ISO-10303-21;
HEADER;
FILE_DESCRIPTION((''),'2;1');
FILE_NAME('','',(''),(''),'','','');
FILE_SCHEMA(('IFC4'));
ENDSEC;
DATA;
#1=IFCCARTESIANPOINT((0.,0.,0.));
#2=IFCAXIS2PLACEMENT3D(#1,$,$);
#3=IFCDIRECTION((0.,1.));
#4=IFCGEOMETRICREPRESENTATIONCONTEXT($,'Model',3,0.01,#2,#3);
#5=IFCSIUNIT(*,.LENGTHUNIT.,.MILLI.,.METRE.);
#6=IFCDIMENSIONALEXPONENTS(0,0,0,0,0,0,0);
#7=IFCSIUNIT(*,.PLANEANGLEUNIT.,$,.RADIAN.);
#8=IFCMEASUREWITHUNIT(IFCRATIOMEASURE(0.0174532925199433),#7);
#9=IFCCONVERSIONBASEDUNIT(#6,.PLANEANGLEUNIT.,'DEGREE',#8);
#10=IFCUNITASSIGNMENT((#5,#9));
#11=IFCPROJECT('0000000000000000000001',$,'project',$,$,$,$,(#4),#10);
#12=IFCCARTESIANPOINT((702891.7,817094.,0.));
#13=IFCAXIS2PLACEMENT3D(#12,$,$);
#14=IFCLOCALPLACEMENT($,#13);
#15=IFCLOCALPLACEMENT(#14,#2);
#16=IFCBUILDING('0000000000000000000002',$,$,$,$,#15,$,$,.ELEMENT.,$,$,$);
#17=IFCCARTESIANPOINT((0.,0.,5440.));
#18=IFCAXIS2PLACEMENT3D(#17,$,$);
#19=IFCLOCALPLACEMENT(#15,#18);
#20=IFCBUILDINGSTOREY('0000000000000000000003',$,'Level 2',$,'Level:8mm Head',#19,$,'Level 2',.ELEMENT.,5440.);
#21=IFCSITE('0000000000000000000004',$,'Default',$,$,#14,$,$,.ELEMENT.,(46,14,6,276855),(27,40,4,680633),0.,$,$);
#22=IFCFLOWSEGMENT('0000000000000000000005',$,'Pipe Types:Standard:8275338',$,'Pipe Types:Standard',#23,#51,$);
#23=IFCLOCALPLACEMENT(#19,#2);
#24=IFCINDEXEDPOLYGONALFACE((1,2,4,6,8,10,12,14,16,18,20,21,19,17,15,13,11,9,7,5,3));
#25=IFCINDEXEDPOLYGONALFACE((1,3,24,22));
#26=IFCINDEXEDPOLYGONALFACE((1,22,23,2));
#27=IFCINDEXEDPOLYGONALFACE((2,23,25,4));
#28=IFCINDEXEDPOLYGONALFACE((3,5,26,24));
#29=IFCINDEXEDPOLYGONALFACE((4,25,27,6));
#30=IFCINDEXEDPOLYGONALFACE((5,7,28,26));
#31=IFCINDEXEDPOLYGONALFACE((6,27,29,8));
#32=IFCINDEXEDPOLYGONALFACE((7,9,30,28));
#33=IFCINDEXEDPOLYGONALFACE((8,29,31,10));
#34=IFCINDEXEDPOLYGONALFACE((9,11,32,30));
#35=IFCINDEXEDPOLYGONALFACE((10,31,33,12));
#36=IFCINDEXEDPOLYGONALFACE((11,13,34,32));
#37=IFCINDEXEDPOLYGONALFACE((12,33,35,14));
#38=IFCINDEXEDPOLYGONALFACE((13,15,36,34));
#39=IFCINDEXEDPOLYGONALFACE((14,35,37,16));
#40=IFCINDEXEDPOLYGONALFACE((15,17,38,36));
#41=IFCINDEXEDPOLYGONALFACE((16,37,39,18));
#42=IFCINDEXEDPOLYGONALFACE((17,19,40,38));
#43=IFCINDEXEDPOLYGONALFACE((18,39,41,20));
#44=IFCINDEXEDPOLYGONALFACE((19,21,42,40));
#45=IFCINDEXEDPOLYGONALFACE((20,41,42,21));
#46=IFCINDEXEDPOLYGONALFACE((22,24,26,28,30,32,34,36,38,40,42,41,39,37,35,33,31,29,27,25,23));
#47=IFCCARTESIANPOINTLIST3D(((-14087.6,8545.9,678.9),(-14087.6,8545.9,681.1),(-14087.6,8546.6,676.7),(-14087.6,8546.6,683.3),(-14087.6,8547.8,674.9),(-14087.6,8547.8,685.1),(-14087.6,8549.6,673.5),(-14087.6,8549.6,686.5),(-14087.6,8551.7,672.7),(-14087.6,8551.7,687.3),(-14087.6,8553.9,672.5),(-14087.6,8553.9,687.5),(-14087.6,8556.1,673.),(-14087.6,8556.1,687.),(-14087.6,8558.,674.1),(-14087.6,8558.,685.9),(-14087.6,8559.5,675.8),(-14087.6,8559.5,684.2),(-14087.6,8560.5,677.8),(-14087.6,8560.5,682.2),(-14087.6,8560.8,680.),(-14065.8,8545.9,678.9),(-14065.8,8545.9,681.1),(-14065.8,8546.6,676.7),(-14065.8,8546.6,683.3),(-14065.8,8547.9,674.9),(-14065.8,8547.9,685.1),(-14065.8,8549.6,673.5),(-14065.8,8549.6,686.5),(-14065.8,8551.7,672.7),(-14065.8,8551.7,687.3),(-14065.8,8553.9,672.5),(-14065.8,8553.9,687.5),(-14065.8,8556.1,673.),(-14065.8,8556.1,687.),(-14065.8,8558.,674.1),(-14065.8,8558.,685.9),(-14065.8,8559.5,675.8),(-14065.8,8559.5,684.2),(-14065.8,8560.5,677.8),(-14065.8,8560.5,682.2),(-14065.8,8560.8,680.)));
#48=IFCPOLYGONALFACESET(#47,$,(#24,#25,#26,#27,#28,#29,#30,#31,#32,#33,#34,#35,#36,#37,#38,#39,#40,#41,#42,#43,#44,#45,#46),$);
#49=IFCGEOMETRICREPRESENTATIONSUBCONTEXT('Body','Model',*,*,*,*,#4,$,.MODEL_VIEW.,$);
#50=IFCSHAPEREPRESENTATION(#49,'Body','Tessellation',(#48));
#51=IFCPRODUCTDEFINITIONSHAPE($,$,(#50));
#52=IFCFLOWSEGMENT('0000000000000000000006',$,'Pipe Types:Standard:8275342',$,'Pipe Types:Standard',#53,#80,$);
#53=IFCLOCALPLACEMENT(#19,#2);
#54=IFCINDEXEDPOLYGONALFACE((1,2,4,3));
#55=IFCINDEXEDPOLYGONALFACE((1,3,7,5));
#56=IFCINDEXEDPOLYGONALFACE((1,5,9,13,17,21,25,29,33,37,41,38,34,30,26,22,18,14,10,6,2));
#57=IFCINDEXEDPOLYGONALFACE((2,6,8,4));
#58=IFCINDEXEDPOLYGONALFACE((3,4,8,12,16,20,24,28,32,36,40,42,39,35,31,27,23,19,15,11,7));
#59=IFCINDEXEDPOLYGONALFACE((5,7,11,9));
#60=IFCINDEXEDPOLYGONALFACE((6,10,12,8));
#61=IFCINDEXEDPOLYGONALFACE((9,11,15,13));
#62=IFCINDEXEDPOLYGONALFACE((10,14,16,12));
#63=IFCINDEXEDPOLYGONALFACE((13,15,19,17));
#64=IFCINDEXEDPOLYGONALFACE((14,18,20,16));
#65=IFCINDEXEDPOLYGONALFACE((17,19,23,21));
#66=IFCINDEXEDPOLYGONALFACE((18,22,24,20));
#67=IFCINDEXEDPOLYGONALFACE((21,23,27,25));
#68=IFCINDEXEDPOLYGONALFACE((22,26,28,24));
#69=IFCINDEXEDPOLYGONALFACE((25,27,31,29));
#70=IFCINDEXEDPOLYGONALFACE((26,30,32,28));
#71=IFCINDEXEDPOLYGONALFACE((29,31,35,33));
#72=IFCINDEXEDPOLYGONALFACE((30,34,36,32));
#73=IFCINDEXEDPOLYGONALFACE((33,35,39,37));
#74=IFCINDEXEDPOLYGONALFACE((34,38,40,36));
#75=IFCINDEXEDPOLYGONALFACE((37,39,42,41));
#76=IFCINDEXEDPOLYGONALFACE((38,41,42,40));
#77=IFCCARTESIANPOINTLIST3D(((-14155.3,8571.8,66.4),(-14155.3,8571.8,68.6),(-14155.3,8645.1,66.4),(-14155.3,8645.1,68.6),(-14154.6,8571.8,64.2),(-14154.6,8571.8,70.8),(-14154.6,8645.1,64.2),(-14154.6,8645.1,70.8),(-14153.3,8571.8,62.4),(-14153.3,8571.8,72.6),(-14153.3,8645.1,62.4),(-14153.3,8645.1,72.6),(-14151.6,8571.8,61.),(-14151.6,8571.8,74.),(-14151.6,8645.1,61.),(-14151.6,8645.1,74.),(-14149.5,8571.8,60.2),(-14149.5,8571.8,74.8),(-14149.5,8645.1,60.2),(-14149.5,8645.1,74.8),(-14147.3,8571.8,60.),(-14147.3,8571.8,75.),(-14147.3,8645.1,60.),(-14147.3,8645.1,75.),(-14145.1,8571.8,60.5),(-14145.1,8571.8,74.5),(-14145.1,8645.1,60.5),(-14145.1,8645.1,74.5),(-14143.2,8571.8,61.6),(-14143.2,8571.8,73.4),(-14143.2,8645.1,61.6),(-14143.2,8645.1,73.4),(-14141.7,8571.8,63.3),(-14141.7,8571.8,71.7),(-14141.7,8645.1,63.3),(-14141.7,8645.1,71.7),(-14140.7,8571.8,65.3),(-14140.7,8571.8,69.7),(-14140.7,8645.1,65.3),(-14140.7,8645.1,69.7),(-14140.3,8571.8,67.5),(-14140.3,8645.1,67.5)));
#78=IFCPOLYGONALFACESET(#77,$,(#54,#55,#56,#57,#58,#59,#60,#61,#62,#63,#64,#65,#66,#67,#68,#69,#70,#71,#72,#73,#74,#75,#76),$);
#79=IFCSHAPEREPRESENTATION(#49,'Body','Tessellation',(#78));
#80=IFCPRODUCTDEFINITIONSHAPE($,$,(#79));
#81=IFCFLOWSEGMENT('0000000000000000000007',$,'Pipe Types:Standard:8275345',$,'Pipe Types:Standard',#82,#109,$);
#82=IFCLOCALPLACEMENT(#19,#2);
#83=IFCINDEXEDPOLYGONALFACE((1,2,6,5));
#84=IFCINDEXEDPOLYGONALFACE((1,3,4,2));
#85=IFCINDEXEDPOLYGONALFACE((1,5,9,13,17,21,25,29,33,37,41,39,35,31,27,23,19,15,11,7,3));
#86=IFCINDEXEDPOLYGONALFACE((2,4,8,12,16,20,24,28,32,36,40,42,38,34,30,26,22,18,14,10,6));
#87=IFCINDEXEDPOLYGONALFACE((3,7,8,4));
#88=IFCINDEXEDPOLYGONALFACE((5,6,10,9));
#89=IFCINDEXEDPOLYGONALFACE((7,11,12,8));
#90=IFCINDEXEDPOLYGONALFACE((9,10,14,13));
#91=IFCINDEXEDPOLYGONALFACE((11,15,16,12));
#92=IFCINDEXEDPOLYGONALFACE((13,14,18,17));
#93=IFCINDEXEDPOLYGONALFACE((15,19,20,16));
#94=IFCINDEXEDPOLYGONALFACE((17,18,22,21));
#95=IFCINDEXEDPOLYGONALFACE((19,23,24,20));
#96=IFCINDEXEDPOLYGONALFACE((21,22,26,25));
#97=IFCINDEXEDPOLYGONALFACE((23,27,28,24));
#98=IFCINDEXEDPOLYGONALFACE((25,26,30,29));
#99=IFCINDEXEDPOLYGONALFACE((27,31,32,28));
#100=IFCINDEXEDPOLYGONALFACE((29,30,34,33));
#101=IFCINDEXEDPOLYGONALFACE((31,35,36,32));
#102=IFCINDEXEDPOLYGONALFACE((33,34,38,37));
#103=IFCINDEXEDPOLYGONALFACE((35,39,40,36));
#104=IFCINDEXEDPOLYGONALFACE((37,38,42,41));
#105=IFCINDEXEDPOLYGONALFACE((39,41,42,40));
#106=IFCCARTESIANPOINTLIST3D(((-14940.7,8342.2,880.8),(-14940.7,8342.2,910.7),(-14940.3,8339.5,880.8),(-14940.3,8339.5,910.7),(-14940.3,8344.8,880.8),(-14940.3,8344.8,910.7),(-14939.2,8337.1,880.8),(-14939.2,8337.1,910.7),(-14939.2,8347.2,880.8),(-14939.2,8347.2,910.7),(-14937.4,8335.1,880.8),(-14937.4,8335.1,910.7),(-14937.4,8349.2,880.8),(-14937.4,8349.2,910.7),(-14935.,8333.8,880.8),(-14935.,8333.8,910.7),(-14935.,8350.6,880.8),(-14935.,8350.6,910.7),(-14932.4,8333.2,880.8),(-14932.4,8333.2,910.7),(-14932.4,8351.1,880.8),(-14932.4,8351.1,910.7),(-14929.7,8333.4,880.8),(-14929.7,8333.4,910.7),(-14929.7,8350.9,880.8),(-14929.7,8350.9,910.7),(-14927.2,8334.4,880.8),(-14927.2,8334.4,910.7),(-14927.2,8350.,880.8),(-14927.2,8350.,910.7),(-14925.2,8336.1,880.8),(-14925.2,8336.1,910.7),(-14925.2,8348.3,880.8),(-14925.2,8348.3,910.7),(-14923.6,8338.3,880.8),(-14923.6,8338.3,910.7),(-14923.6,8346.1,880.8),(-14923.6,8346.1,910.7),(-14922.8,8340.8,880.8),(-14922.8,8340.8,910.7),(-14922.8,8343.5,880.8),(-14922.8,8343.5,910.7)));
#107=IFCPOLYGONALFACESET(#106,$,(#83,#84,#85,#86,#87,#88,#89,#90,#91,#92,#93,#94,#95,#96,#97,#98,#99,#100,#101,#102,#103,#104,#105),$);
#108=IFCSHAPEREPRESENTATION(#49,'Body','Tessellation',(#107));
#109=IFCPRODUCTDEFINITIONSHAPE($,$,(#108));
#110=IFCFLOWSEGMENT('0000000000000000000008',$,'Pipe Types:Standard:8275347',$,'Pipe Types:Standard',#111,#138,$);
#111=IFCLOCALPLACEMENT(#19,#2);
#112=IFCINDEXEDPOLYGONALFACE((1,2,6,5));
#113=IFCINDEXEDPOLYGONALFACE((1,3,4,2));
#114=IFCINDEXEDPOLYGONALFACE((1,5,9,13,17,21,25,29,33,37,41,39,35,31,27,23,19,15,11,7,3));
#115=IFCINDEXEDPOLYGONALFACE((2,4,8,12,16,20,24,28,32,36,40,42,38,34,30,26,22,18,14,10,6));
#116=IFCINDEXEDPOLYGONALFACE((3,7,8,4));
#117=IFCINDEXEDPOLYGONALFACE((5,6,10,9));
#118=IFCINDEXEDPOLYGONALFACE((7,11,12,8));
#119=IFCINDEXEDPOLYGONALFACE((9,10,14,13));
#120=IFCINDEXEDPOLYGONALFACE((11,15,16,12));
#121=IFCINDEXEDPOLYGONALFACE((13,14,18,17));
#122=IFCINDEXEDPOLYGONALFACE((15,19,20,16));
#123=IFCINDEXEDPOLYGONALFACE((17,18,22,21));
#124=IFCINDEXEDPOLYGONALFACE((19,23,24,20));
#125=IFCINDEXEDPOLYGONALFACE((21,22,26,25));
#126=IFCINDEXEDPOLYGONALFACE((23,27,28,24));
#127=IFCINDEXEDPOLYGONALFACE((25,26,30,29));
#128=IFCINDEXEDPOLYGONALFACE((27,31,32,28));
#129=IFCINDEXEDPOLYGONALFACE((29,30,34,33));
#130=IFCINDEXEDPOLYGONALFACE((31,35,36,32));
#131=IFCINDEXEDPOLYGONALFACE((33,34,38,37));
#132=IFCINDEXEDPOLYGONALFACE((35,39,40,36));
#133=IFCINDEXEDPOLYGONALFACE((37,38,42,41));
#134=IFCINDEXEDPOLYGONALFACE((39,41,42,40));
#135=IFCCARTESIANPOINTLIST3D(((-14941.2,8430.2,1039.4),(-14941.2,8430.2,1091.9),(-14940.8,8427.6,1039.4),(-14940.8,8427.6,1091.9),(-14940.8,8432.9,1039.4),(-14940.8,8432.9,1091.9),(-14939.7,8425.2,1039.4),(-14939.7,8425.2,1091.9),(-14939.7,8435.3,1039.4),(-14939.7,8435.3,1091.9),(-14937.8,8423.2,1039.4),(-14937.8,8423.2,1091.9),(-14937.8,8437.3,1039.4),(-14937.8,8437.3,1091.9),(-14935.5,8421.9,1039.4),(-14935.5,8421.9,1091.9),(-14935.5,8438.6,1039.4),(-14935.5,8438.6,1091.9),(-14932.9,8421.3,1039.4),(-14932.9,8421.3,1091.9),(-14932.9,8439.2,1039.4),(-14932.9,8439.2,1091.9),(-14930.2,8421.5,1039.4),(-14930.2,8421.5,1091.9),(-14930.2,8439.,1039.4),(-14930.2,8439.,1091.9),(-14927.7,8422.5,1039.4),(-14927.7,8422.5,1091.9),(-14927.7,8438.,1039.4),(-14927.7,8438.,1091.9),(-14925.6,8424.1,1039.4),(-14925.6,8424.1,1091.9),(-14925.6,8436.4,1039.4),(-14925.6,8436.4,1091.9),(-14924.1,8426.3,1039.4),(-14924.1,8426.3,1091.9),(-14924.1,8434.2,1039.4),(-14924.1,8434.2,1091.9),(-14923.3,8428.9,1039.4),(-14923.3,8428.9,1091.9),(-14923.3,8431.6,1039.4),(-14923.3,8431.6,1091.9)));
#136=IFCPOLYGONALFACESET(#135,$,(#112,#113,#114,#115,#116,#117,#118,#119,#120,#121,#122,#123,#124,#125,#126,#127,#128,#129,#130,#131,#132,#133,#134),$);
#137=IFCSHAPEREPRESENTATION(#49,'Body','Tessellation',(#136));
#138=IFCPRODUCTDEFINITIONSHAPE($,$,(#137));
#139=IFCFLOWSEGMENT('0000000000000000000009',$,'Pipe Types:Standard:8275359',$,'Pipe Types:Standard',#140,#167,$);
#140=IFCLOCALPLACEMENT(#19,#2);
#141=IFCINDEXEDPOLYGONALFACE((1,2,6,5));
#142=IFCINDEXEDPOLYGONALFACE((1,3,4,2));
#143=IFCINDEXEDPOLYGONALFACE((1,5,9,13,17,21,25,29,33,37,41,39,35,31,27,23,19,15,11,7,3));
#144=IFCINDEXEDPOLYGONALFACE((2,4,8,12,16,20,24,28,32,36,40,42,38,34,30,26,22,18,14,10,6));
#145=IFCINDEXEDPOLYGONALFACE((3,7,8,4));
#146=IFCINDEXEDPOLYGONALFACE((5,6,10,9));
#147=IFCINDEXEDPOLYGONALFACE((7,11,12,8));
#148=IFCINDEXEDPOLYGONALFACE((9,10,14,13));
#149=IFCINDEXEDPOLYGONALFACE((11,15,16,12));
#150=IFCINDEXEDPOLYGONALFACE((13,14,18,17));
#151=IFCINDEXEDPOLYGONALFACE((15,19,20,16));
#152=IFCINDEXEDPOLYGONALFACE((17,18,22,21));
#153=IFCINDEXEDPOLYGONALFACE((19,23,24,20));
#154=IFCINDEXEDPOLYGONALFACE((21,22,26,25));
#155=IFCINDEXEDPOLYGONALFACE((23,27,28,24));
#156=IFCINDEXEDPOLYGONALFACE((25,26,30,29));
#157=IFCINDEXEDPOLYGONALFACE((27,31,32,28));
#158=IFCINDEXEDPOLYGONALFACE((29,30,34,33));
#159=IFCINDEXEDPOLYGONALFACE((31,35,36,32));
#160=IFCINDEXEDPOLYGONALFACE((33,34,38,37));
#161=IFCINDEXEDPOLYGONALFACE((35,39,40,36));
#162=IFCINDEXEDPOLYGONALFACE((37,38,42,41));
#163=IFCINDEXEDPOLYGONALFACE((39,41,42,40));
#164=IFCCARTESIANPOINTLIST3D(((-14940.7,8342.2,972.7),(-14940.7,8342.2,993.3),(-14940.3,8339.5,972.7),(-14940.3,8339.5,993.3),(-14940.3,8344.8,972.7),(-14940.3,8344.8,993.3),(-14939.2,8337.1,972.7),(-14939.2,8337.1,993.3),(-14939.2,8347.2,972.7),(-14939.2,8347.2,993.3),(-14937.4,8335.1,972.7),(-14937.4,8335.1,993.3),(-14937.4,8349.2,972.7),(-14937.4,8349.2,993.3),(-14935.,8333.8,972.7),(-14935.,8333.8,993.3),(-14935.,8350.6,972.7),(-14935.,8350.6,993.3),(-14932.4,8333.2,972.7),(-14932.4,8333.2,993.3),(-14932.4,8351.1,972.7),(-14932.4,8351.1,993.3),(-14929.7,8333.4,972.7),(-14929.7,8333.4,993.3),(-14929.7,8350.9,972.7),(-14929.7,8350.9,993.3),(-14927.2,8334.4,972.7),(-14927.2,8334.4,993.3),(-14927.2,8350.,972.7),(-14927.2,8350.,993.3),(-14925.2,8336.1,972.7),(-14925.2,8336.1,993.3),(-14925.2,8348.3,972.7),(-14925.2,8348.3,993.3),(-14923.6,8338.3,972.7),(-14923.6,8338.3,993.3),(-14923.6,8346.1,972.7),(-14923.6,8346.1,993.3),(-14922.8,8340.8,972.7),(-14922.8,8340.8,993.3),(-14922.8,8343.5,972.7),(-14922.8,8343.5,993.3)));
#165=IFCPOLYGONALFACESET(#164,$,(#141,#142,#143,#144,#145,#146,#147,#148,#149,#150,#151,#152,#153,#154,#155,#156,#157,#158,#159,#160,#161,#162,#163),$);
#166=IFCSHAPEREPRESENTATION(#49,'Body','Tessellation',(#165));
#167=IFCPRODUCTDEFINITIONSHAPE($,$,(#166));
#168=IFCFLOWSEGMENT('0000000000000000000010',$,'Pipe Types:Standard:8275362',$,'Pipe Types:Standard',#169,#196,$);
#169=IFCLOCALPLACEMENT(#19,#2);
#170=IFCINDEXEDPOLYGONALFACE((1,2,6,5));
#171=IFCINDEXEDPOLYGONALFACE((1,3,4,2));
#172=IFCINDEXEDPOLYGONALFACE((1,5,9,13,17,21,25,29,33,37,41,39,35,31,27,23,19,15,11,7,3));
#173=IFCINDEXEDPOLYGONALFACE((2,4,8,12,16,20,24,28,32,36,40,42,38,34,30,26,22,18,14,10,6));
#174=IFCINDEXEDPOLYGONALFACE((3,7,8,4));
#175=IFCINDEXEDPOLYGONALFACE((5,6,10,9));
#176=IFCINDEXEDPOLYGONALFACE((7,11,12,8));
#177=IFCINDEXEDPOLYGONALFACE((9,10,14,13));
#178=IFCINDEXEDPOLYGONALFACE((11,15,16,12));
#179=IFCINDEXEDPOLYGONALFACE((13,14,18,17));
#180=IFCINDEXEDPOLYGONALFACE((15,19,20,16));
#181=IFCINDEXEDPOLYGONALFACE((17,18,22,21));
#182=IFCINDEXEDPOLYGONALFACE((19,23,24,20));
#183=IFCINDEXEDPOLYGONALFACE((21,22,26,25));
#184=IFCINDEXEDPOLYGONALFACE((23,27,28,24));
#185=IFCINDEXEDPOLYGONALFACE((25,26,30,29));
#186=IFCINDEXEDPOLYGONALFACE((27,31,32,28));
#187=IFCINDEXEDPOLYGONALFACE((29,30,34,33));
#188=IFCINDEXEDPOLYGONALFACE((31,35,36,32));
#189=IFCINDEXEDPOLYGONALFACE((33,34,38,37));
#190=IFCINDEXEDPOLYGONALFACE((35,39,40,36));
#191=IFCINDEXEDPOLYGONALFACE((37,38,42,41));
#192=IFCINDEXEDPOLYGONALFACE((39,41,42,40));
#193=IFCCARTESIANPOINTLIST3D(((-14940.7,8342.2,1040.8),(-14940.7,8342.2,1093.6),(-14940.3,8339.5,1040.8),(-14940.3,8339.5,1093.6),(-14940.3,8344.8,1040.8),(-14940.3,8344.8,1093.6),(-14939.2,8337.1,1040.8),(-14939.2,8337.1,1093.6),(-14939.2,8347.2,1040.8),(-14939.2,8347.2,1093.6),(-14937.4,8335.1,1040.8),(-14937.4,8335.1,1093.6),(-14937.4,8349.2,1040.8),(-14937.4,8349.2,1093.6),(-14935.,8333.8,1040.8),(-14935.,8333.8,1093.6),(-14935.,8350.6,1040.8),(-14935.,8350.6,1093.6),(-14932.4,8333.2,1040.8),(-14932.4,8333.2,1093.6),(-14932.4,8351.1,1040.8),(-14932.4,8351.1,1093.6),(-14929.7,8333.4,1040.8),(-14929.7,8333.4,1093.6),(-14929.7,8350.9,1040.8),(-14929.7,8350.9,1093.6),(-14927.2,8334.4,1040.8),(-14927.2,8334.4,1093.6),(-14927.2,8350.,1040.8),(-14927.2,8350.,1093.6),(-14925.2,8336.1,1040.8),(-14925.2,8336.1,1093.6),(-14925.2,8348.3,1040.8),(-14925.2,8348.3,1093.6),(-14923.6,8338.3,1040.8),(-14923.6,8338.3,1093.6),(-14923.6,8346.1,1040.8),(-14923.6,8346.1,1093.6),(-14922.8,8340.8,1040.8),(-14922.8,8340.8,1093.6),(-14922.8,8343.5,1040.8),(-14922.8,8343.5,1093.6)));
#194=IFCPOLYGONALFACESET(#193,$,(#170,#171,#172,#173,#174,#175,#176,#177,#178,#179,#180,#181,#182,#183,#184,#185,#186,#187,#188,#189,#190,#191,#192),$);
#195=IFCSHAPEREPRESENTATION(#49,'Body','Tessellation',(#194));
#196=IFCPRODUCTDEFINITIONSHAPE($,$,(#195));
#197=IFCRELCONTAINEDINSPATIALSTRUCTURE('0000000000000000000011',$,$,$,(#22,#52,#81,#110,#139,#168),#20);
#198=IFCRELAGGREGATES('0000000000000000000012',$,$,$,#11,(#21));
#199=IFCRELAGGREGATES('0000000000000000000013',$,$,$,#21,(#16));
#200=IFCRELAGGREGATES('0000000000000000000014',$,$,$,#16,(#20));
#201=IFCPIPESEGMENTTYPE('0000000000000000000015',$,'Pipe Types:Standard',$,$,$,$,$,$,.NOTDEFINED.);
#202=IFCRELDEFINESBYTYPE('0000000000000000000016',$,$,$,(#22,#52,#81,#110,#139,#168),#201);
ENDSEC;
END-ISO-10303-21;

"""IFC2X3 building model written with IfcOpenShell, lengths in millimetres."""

from ifc_helpers import new_model, entity, si_unit, converted_unit, direction, frame, frame_2d, origin, origin_2d_with_axis, place, context, subcontext, project, spatial, circle, extrude, type_object, element, save


model = new_model("IFC2X3")

# Units and contexts
model_context = context("Model", 3, precision=0.01, world=origin(), true_north=direction((0.0, 1.0)))
body_context = subcontext(model_context, "Body", "Model", "MODEL_VIEW")
ifc_project = project(units=[si_unit("LENGTHUNIT", "METRE", prefix="MILLI"), converted_unit("PLANEANGLEUNIT", "DEGREE", entity("IfcRatioMeasure", 0.0174532925199433), si_unit("PLANEANGLEUNIT", "RADIAN"), dimensions=[0, 0, 0, 0, 0, 0, 0])], contexts=[model_context])

# Site, building, storey
site_placement = place(None, frame((702891.7, 817094.0, 0.0)))
site = spatial("IfcSite", under=ifc_project, at=site_placement, Name="Default", CompositionType="ELEMENT", RefLatitude=(46, 14, 6, 276855), RefLongitude=(27, 40, 4, 680633), RefElevation=0.0)
building_placement = place(site_placement, origin())
building = spatial("IfcBuilding", under=site, at=building_placement, CompositionType="ELEMENT")
storey_placement = place(building_placement, frame((0.0, 0.0, 5440.0)))
storey = spatial("IfcBuildingStorey", under=building, at=storey_placement, Name="Level 2", ObjectType="Level:8mm Head", LongName="Level 2", CompositionType="ELEMENT", Elevation=5440.0)

# Flow segments
pipe_segment_type = type_object("IfcPipeSegmentType", Name="Pipe Types:Standard", PredefinedType="NOTDEFINED")
flow_segment_1_placement = place(storey_placement, origin())
element("IfcFlowSegment", 1, at=flow_segment_1_placement, inside=storey, type_object=pipe_segment_type, Name="Pipe Types:Standard:8275338", ObjectType="Pipe Types:Standard", context=body_context, shape_type="SweptSolid", body=[
    extrude(circle(Radius=7.5, at=origin_2d_with_axis()), frame((-14087.6, 8553.3, 680.0), z_axis=(1.0, 0.000154, 0.0), x_axis=(-0.000154, 1.0, 0.0)), (0.0, 0.0, 1.0), 21.8),
])
flow_segment_2_placement = place(storey_placement, origin())
element("IfcFlowSegment", 2, at=flow_segment_2_placement, inside=storey, type_object=pipe_segment_type, Name="Pipe Types:Standard:8275342", ObjectType="Pipe Types:Standard", context=body_context, shape_type="SweptSolid", body=[
    extrude(circle(Radius=7.5, at=origin_2d_with_axis()), frame((-14147.8, 8571.8, 67.5), z_axis=(0.0, 1.0, 0.0), x_axis=(1.0, 0.0, 0.0)), (0.0, 0.0, 1.0), 73.3),
])
flow_segment_3_placement = place(storey_placement, origin())
element("IfcFlowSegment", 3, at=flow_segment_3_placement, inside=storey, type_object=pipe_segment_type, Name="Pipe Types:Standard:8275345", ObjectType="Pipe Types:Standard", context=body_context, shape_type="SweptSolid", body=[
    extrude(circle(Radius=9.0, at=origin_2d_with_axis()), frame((-14931.7, 8342.2, 880.8), z_axis=(0.0, 0.0, 1.0), x_axis=(-1.0, 0.0, 0.0)), (0.0, 0.0, 1.0), 29.9),
])
flow_segment_4_placement = place(storey_placement, origin())
element("IfcFlowSegment", 4, at=flow_segment_4_placement, inside=storey, type_object=pipe_segment_type, Name="Pipe Types:Standard:8275347", ObjectType="Pipe Types:Standard", context=body_context, shape_type="SweptSolid", body=[
    extrude(circle(Radius=9.0, at=origin_2d_with_axis()), frame((-14932.2, 8430.2, 1039.4), z_axis=(0.0, 0.0, 1.0), x_axis=(-1.0, 0.0, 0.0)), (0.0, 0.0, 1.0), 52.5),
])
flow_segment_5_placement = place(storey_placement, origin())
element("IfcFlowSegment", 5, at=flow_segment_5_placement, inside=storey, type_object=pipe_segment_type, Name="Pipe Types:Standard:8275359", ObjectType="Pipe Types:Standard", context=body_context, shape_type="SweptSolid", body=[
    extrude(circle(Radius=9.0, at=origin_2d_with_axis()), frame((-14931.7, 8342.2, 972.7), z_axis=(0.0, 0.0, 1.0), x_axis=(-1.0, 0.0, 0.0)), (0.0, 0.0, 1.0), 20.6),
])
flow_segment_6_placement = place(storey_placement, origin())
element("IfcFlowSegment", 6, at=flow_segment_6_placement, inside=storey, type_object=pipe_segment_type, Name="Pipe Types:Standard:8275362", ObjectType="Pipe Types:Standard", context=body_context, shape_type="SweptSolid", body=[
    extrude(circle(Radius=9.0, at=frame_2d((0.0, 0.0), x_axis=(1.0, 0.0))), frame((-14931.7, 8342.2, 1040.8), z_axis=(0.0, 0.0, 1.0), x_axis=(-1.0, 0.0, 0.0)), (0.0, 0.0, 1.0), 52.8),
])

save(model, "model.ifc")
